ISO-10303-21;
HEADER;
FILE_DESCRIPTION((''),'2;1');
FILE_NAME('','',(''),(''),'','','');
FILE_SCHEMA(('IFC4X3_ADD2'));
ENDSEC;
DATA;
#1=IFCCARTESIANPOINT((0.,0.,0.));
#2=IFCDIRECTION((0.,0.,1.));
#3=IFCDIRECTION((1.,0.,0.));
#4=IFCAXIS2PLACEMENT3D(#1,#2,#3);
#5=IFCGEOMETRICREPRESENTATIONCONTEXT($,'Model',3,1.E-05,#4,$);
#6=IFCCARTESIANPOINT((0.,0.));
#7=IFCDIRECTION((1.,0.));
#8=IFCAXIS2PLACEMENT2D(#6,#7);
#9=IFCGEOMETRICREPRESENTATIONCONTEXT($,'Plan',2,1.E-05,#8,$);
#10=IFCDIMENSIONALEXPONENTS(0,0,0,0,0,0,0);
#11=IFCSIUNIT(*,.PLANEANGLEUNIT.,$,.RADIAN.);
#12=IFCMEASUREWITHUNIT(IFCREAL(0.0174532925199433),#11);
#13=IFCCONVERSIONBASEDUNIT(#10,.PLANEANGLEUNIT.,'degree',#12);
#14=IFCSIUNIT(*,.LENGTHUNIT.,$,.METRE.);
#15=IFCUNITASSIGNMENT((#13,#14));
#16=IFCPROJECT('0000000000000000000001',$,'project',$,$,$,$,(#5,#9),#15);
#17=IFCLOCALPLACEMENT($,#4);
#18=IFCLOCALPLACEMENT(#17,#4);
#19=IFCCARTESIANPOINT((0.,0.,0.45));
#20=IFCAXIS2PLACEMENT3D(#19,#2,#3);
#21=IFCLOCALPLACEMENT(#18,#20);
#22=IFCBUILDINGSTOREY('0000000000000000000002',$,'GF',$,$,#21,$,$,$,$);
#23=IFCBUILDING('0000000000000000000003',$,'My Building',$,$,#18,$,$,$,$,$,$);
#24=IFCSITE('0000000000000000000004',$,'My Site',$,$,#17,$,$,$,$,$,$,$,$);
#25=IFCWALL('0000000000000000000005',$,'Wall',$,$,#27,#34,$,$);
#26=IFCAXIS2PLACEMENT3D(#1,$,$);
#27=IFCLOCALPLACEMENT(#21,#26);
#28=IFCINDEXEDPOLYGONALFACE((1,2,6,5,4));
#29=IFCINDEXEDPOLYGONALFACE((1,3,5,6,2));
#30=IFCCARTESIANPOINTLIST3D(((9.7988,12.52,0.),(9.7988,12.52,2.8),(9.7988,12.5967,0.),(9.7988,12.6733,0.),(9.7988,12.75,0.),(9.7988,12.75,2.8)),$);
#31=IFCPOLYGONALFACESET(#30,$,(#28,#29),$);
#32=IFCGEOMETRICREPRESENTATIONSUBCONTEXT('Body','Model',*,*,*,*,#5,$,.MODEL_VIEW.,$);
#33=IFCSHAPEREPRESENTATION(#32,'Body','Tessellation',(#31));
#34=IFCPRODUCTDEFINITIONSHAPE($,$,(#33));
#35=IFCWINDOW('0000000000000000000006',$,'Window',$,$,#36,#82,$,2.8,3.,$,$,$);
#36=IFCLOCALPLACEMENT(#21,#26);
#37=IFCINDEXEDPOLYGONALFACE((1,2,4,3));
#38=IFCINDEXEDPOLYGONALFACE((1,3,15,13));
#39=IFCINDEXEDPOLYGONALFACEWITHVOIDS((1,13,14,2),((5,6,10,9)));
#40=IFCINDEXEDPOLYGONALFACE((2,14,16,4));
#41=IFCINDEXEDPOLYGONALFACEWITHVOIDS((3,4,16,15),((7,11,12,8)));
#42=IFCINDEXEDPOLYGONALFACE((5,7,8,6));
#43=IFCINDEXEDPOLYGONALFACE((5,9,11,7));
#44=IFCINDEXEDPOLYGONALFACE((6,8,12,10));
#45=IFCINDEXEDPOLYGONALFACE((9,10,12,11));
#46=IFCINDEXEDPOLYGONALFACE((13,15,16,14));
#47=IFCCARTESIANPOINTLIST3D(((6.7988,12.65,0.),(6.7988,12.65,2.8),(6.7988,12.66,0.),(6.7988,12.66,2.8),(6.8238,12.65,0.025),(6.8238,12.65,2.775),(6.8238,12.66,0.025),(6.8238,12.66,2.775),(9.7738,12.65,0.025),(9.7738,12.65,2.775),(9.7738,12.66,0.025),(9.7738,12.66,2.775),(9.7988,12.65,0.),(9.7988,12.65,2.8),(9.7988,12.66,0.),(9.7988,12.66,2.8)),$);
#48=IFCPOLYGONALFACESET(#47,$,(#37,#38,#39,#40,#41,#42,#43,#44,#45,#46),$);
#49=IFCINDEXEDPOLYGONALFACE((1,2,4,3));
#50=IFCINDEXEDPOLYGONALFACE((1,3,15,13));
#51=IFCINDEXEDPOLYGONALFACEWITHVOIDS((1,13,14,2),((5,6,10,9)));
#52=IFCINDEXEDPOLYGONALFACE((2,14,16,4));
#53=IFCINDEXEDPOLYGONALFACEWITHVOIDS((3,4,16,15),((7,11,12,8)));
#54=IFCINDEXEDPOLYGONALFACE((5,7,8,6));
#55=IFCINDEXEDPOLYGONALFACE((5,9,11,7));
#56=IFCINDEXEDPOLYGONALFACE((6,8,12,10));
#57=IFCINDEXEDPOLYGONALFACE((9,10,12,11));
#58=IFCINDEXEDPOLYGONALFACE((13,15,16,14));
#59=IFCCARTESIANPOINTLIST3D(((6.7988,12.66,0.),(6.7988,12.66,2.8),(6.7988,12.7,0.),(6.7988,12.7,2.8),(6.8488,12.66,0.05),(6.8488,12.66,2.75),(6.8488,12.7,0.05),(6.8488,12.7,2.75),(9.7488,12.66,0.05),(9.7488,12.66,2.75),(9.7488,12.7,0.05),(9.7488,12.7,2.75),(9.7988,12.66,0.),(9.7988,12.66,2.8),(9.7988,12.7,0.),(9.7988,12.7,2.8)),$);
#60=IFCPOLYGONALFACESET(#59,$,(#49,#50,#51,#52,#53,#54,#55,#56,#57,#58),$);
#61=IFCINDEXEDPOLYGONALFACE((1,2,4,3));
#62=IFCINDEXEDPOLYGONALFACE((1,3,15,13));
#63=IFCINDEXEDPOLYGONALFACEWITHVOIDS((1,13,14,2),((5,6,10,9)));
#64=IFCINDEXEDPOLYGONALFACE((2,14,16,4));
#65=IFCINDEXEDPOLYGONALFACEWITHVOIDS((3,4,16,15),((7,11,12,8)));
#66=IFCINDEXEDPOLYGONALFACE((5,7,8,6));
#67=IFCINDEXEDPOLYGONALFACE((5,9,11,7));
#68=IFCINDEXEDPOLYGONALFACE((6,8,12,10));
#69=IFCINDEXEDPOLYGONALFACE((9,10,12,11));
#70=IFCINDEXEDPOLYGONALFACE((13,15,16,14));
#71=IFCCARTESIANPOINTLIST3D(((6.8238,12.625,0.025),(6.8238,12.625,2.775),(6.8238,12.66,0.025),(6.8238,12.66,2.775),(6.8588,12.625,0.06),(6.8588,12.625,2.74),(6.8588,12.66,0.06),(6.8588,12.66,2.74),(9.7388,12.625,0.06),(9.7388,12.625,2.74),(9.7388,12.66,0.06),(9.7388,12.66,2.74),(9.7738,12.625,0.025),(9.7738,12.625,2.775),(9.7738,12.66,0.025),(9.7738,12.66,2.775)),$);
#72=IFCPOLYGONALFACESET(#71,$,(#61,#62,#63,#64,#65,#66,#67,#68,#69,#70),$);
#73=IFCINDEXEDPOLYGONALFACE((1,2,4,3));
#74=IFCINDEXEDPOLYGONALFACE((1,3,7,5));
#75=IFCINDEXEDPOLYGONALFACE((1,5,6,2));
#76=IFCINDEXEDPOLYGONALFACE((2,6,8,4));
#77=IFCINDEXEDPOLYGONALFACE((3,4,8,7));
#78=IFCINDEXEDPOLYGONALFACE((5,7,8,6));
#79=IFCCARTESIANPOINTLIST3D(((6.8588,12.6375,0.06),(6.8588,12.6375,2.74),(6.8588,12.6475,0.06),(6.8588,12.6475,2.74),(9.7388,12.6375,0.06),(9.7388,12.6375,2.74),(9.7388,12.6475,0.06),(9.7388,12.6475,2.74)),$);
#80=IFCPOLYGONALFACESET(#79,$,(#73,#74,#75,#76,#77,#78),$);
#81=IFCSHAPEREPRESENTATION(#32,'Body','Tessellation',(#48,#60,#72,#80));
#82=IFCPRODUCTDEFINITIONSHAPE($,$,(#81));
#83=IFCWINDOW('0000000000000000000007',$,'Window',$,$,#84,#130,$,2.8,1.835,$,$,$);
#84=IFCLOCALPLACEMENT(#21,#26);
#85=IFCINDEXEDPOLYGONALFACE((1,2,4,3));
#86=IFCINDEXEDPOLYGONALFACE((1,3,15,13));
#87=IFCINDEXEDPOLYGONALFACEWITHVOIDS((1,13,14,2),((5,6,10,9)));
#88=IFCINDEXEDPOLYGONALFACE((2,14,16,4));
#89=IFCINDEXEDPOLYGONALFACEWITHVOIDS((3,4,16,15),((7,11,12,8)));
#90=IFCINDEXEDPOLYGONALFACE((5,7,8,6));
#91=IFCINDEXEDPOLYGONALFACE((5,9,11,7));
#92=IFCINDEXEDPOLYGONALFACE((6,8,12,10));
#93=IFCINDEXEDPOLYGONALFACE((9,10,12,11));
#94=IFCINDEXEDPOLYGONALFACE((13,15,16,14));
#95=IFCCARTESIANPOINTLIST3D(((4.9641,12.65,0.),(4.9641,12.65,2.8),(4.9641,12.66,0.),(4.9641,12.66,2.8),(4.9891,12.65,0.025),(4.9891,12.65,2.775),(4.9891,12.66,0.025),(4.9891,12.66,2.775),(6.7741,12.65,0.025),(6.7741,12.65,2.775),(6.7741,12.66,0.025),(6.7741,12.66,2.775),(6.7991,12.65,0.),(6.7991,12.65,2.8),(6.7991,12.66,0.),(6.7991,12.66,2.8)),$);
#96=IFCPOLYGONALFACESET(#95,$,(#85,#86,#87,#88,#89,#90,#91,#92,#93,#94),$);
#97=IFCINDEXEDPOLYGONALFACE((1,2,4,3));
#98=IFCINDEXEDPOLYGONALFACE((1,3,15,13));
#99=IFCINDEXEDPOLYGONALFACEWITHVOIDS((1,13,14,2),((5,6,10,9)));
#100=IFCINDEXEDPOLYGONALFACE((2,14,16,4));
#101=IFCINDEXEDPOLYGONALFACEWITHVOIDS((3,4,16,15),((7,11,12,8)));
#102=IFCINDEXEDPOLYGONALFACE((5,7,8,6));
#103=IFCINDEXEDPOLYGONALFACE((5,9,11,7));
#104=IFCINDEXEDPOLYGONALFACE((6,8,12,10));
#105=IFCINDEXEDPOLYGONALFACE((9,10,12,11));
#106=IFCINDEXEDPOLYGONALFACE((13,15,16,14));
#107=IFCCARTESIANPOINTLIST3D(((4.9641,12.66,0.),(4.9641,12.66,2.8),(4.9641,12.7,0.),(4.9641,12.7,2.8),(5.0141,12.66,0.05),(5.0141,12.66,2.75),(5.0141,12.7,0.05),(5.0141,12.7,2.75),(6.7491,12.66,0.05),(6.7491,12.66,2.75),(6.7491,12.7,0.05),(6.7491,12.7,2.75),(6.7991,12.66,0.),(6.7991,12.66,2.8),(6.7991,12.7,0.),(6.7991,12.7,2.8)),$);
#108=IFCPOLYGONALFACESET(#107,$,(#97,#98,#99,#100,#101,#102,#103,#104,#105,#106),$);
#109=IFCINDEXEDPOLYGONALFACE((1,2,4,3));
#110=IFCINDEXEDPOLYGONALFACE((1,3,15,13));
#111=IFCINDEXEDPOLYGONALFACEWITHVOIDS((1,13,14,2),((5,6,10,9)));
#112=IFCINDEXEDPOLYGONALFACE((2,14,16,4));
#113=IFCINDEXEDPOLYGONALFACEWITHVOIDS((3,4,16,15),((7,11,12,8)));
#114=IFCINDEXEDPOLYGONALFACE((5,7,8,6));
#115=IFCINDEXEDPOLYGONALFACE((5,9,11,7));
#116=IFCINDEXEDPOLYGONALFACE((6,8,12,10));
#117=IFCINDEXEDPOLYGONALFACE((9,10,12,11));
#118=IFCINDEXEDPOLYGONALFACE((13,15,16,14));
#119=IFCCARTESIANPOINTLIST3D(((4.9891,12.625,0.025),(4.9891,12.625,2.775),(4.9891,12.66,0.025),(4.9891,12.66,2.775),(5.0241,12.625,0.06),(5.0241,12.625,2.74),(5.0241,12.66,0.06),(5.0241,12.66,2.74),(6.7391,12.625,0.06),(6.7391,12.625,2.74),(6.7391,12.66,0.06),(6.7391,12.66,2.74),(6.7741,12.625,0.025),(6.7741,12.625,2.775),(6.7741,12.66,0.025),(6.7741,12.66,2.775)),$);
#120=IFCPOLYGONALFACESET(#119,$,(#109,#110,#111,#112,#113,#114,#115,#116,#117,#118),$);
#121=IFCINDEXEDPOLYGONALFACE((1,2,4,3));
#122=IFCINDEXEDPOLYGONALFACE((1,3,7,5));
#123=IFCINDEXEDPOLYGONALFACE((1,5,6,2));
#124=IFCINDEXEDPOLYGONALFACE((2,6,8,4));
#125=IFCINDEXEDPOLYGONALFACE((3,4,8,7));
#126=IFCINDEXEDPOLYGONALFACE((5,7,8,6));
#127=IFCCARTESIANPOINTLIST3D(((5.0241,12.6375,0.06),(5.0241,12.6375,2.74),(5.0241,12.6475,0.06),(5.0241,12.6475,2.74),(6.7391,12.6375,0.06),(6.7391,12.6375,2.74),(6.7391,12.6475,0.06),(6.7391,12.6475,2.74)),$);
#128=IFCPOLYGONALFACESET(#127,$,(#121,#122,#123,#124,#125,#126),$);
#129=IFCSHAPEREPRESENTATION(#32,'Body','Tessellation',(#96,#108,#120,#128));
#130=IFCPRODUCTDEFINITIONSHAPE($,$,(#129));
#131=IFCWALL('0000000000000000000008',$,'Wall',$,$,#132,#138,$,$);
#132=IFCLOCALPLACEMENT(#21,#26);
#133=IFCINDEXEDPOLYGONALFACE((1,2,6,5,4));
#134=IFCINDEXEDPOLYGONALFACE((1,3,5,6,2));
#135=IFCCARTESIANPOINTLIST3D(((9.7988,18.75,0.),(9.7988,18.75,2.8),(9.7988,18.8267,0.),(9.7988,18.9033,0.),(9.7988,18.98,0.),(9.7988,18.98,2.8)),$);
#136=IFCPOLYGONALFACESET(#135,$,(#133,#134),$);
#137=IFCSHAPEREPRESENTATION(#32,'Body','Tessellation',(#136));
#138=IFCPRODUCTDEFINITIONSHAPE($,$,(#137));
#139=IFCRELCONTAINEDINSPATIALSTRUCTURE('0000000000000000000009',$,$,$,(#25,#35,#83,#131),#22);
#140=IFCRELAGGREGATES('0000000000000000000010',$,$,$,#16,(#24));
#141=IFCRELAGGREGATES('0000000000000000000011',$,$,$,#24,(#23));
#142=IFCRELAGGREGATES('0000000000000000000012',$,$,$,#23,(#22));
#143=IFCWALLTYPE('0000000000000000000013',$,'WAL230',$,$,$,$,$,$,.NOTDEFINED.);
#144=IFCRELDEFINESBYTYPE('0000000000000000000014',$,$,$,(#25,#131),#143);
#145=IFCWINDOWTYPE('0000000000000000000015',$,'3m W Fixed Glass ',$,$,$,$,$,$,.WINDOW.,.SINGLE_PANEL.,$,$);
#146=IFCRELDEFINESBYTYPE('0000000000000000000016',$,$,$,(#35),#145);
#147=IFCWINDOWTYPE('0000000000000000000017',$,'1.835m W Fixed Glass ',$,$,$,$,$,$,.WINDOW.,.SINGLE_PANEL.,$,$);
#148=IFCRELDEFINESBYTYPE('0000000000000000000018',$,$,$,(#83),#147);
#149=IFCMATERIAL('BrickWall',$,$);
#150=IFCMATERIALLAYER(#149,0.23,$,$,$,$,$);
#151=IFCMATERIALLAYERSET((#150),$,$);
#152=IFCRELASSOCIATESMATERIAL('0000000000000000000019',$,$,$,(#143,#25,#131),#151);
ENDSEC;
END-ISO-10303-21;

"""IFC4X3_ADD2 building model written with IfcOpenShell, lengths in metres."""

from ifc_helpers import new_model, entity, si_unit, converted_unit, frame, origin_with_axes, origin_2d_with_axis, place, context, subcontext, project, spatial, line, indexed_curve, outline, extrude, shape, source, transform, mapped, material, layer, layer_set, layer_usage, type_object, type_shapes, element, fill, save


model = new_model("IFC4X3_ADD2")

# Units and contexts
model_context = context("Model", 3, precision=1e-05, world=origin_with_axes())
plan_context = context("Plan", 2, precision=1e-05, world=origin_2d_with_axis())
body_context_1 = subcontext(model_context, "Body", "Model", "MODEL_VIEW")
body_context_2 = subcontext(plan_context, "Body", "Plan", "PLAN_VIEW")
ifc_project = project(units=[converted_unit("PLANEANGLEUNIT", "degree", entity("IfcReal", 0.0174532925199433), si_unit("PLANEANGLEUNIT", "RADIAN"), dimensions=[0, 0, 0, 0, 0, 0, 0]), si_unit("LENGTHUNIT", "METRE")], contexts=[model_context, plan_context])

# Site, building, storey
site_placement = place(None, origin_with_axes())
site = spatial("IfcSite", under=ifc_project, at=site_placement, Name="My Site")
building_placement = place(site_placement, origin_with_axes())
building = spatial("IfcBuilding", under=site, at=building_placement, Name="My Building")
storey_placement = place(building_placement, frame((0.0, 0.0, 0.45), z_axis=(0.0, 0.0, 1.0), x_axis=(1.0, 0.0, 0.0)))
storey = spatial("IfcBuildingStorey", under=building, at=storey_placement, Name="GF")

# Wall, openings, windows
ifc_material_1 = material(Name="BrickWall")
ifc_layer_1 = layer(ifc_material_1, 0.23)
ifc_layer_set_1 = layer_set([ifc_layer_1])
wall_type_1 = type_object("IfcWallType", Name="WAL230", PredefinedType="NOTDEFINED", material=ifc_layer_set_1)
ifc_layer_usage_1 = layer_usage(ifc_layer_set_1, "AXIS2", "POSITIVE", 0.0)
wall_1_placement = place(storey_placement, frame((9.7988, 12.75, 0.0), z_axis=(0.0, 0.0, 1.0), x_axis=(-1.0, 0.0, 0.0)))
wall_1 = element("IfcWall", 1, at=wall_1_placement, inside=storey, type_object=wall_type_1, material=ifc_layer_usage_1, Name="Wall", context=body_context_1, shape_type="SweptSolid", body=[
    extrude(outline(indexed_curve([(0.0, 0.0), (0.0, 0.23), (0.0, 0.23), (0.0, 0.0), (0.0, 0.0)], self_intersect=False)), origin_with_axes(), (0.0, 0.0, 1.0), 2.8),
])
shared_shape_1 = source(origin_with_axes(), body_context_1, "Body", "SweptSolid", [
    extrude(outline(indexed_curve([(0.0, 0.0), (3.0, 0.0), (3.0, 2.8), (0.0, 2.8)], segments=[line(1, 2, 3, 4, 1)])), frame((0.0, -0.6, 0.0), z_axis=(0.0, -1.0, 0.0), x_axis=(1.0, 0.0, 0.0)), (0.0, 0.0, -1.0), 1.2),
])
opening_1_placement = place(wall_1_placement, frame((0.0, 0.0, 0.0), z_axis=(0.0, 0.0, 1.0), x_axis=(1.0, 0.0, 0.0)))
opening_1 = element("IfcOpeningElement", 2, at=opening_1_placement, cuts=wall_1, PredefinedType="OPENING", context=body_context_1, shape_type="MappedRepresentation", body=[
    mapped(shared_shape_1, transform((0.0, 0.0, 0.0), x_axis=(1.0, 0.0, 0.0), y_axis=(0.0, 1.0, 0.0), z_axis=(0.0, 0.0, 1.0), scale=1.0)),
])
shared_shape_2 = source(origin_with_axes(), body_context_1, "Body", "SweptSolid", [
    extrude(outline(indexed_curve([(0.0, 0.0), (1.835, 0.0), (1.835, 2.8), (0.0, 2.8)], segments=[line(1, 2, 3, 4, 1)])), frame((0.0, -0.6, 0.0), z_axis=(0.0, -1.0, 0.0), x_axis=(1.0, 0.0, 0.0)), (0.0, 0.0, -1.0), 1.2),
])
opening_2_placement = place(wall_1_placement, frame((2.9997, 0.0, 0.0), z_axis=(0.0, 0.0, 1.0), x_axis=(1.0, 0.0, 0.0)))
opening_2 = element("IfcOpeningElement", 3, at=opening_2_placement, cuts=wall_1, PredefinedType="OPENING", context=body_context_1, shape_type="MappedRepresentation", body=[
    mapped(shared_shape_2, transform((0.0, 0.0, 0.0), x_axis=(1.0, 0.0, 0.0), y_axis=(0.0, 1.0, 0.0), z_axis=(0.0, 0.0, 1.0), scale=1.0)),
])
window_type_1 = type_object("IfcWindowType", Name="3m W Fixed Glass ", PartitioningType="SINGLE_PANEL", PredefinedType="WINDOW")
shared_shape_3 = source(origin_with_axes(), body_context_1, "Body", "SweptSolid", [
    extrude(outline(indexed_curve([(0.0, 0.0), (3.0, 0.0), (3.0, 2.8), (0.0, 2.8)], segments=[line(1, 2, 3, 4, 1)]), holes=[indexed_curve([(0.025, 0.025), (2.975, 0.025), (2.975, 2.775), (0.025, 2.775)], segments=[line(1, 2, 3, 4, 1)])]), frame((0.0, 0.09, 0.0), z_axis=(0.0, -1.0, 0.0), x_axis=(1.0, 0.0, 0.0)), (0.0, 0.0, -1.0), 0.01),
    extrude(outline(indexed_curve([(0.0, 0.0), (3.0, 0.0), (3.0, 2.8), (0.0, 2.8)], segments=[line(1, 2, 3, 4, 1)]), holes=[indexed_curve([(0.05, 0.05), (2.95, 0.05), (2.95, 2.75), (0.05, 2.75)], segments=[line(1, 2, 3, 4, 1)])]), frame((0.0, 0.05, 0.0), z_axis=(0.0, -1.0, 0.0), x_axis=(1.0, 0.0, 0.0)), (0.0, 0.0, -1.0), 0.04),
    extrude(outline(indexed_curve([(0.0, 0.0), (2.95, 0.0), (2.95, 2.75), (0.0, 2.75)], segments=[line(1, 2, 3, 4, 1)]), holes=[indexed_curve([(0.035, 0.035), (2.915, 0.035), (2.915, 2.715), (0.035, 2.715)], segments=[line(1, 2, 3, 4, 1)])]), frame((0.025, 0.09, 0.025), z_axis=(0.0, -1.0, 0.0), x_axis=(1.0, 0.0, 0.0)), (0.0, 0.0, -1.0), 0.035),
    extrude(outline(indexed_curve([(0.035, 0.035), (2.915, 0.035), (2.915, 2.715), (0.035, 2.715)], segments=[line(1, 2, 3, 4, 1)])), frame((0.025, 0.1025, 0.025), z_axis=(0.0, -1.0, 0.0), x_axis=(1.0, 0.0, 0.0)), (0.0, 0.0, -1.0), 0.01),
])
shared_shape_4 = source(origin_with_axes(), body_context_2, "Body", "Curve2D", [
    entity("IfcIndexedPolyCurve", entity("IfcCartesianPointList2D", [[0.05, 0.05], [2.95, 0.05]])),
    entity("IfcIndexedPolyCurve", entity("IfcCartesianPointList2D", [[0.0, 0.1], [0.025, 0.1], [0.025, 0.09], [0.05, 0.09], [0.05, 0.05], [0.0, 0.05]]), [entity("IfcLineIndex", [1, 2, 3, 4, 5, 6, 1])]),
    entity("IfcIndexedPolyCurve", entity("IfcCartesianPointList2D", [[3.0, 0.1], [2.975, 0.1], [2.975, 0.09], [2.95, 0.09], [2.95, 0.05], [3.0, 0.05]]), [entity("IfcLineIndex", [1, 2, 3, 4, 5, 6, 1])]),
    entity("IfcIndexedPolyCurve", entity("IfcCartesianPointList2D", [[0.025, 0.09], [0.06, 0.09], [0.06, 0.125], [0.025, 0.125]]), [entity("IfcLineIndex", [1, 2, 3, 4, 1])]),
    entity("IfcIndexedPolyCurve", entity("IfcCartesianPointList2D", [[2.975, 0.09], [2.94, 0.09], [2.94, 0.125], [2.975, 0.125]]), [entity("IfcLineIndex", [1, 2, 3, 4, 1])]),
    entity("IfcIndexedPolyCurve", entity("IfcCartesianPointList2D", [[0.06, 0.09], [2.94, 0.09]])),
    entity("IfcIndexedPolyCurve", entity("IfcCartesianPointList2D", [[0.06, 0.125], [2.94, 0.125]])),
    entity("IfcIndexedPolyCurve", entity("IfcCartesianPointList2D", [[0.06, 0.1075], [2.94, 0.1075]])),
])
type_shapes(window_type_1, [shared_shape_3, shared_shape_4])
window_1_placement = place(opening_1_placement, frame((0.0, 0.0, 0.0), z_axis=(0.0, 0.0, 1.0), x_axis=(1.0, 0.0, 0.0)))
window_1 = element("IfcWindow", 4, at=window_1_placement, inside=storey, type_object=window_type_1, Name="Window", OverallHeight=2.8, OverallWidth=3.0, shapes=[
    shape(body_context_1, "Body", "MappedRepresentation", [mapped(shared_shape_3, transform((0.0, 0.0, 0.0), x_axis=(1.0, 0.0, 0.0), y_axis=(0.0, 1.0, 0.0), z_axis=(0.0, 0.0, 1.0), scale=1.0))]),
    shape(body_context_2, "Body", "MappedRepresentation", [mapped(shared_shape_4, transform((0.0, 0.0, 0.0), x_axis=(1.0, 0.0, 0.0), y_axis=(0.0, 1.0, 0.0), z_axis=(0.0, 0.0, 1.0), scale=1.0))]),
])
fill(opening_1, window_1)
window_type_2 = type_object("IfcWindowType", Name="1.835m W Fixed Glass ", PartitioningType="SINGLE_PANEL", PredefinedType="WINDOW")
shared_shape_5 = source(origin_with_axes(), body_context_1, "Body", "SweptSolid", [
    extrude(outline(indexed_curve([(0.0, 0.0), (1.835, 0.0), (1.835, 2.8), (0.0, 2.8)], segments=[line(1, 2, 3, 4, 1)]), holes=[indexed_curve([(0.025, 0.025), (1.81, 0.025), (1.81, 2.775), (0.025, 2.775)], segments=[line(1, 2, 3, 4, 1)])]), frame((0.0, 0.09, 0.0), z_axis=(0.0, -1.0, 0.0), x_axis=(1.0, 0.0, 0.0)), (0.0, 0.0, -1.0), 0.01),
    extrude(outline(indexed_curve([(0.0, 0.0), (1.835, 0.0), (1.835, 2.8), (0.0, 2.8)], segments=[line(1, 2, 3, 4, 1)]), holes=[indexed_curve([(0.05, 0.05), (1.785, 0.05), (1.785, 2.75), (0.05, 2.75)], segments=[line(1, 2, 3, 4, 1)])]), frame((0.0, 0.05, 0.0), z_axis=(0.0, -1.0, 0.0), x_axis=(1.0, 0.0, 0.0)), (0.0, 0.0, -1.0), 0.04),
    extrude(outline(indexed_curve([(0.0, 0.0), (1.785, 0.0), (1.785, 2.75), (0.0, 2.75)], segments=[line(1, 2, 3, 4, 1)]), holes=[indexed_curve([(0.035, 0.035), (1.75, 0.035), (1.75, 2.715), (0.035, 2.715)], segments=[line(1, 2, 3, 4, 1)])]), frame((0.025, 0.09, 0.025), z_axis=(0.0, -1.0, 0.0), x_axis=(1.0, 0.0, 0.0)), (0.0, 0.0, -1.0), 0.035),
    extrude(outline(indexed_curve([(0.035, 0.035), (1.75, 0.035), (1.75, 2.715), (0.035, 2.715)], segments=[line(1, 2, 3, 4, 1)])), frame((0.025, 0.1025, 0.025), z_axis=(0.0, -1.0, 0.0), x_axis=(1.0, 0.0, 0.0)), (0.0, 0.0, -1.0), 0.01),
])
shared_shape_6 = source(origin_with_axes(), body_context_2, "Body", "Curve2D", [
    entity("IfcIndexedPolyCurve", entity("IfcCartesianPointList2D", [[0.05, 0.05], [1.785, 0.05]])),
    entity("IfcIndexedPolyCurve", entity("IfcCartesianPointList2D", [[0.0, 0.1], [0.025, 0.1], [0.025, 0.09], [0.05, 0.09], [0.05, 0.05], [0.0, 0.05]]), [entity("IfcLineIndex", [1, 2, 3, 4, 5, 6, 1])]),
    entity("IfcIndexedPolyCurve", entity("IfcCartesianPointList2D", [[1.835, 0.1], [1.81, 0.1], [1.81, 0.09], [1.785, 0.09], [1.785, 0.05], [1.835, 0.05]]), [entity("IfcLineIndex", [1, 2, 3, 4, 5, 6, 1])]),
    entity("IfcIndexedPolyCurve", entity("IfcCartesianPointList2D", [[0.025, 0.09], [0.06, 0.09], [0.06, 0.125], [0.025, 0.125]]), [entity("IfcLineIndex", [1, 2, 3, 4, 1])]),
    entity("IfcIndexedPolyCurve", entity("IfcCartesianPointList2D", [[1.81, 0.09], [1.775, 0.09], [1.775, 0.125], [1.81, 0.125]]), [entity("IfcLineIndex", [1, 2, 3, 4, 1])]),
    entity("IfcIndexedPolyCurve", entity("IfcCartesianPointList2D", [[0.06, 0.09], [1.775, 0.09]])),
    entity("IfcIndexedPolyCurve", entity("IfcCartesianPointList2D", [[0.06, 0.125], [1.775, 0.125]])),
    entity("IfcIndexedPolyCurve", entity("IfcCartesianPointList2D", [[0.06, 0.1075], [1.775, 0.1075]])),
])
type_shapes(window_type_2, [shared_shape_5, shared_shape_6])
window_2_placement = place(opening_2_placement, frame((0.0, 0.0, 0.0), z_axis=(0.0, 0.0, 1.0), x_axis=(1.0, 0.0, 0.0)))
window_2 = element("IfcWindow", 5, at=window_2_placement, inside=storey, type_object=window_type_2, Name="Window", OverallHeight=2.8, OverallWidth=1.835, shapes=[
    shape(body_context_1, "Body", "MappedRepresentation", [mapped(shared_shape_5, transform((0.0, 0.0, 0.0), x_axis=(1.0, 0.0, 0.0), y_axis=(0.0, 1.0, 0.0), z_axis=(0.0, 0.0, 1.0), scale=1.0))]),
    shape(body_context_2, "Body", "MappedRepresentation", [mapped(shared_shape_6, transform((0.0, 0.0, 0.0), x_axis=(1.0, 0.0, 0.0), y_axis=(0.0, 1.0, 0.0), z_axis=(0.0, 0.0, 1.0), scale=1.0))]),
])
fill(opening_2, window_2)

# Wall
ifc_layer_usage_2 = layer_usage(ifc_layer_set_1, "AXIS2", "POSITIVE", 0.0)
wall_2_placement = place(storey_placement, frame((9.7988, 18.98, 0.0), z_axis=(0.0, 0.0, 1.0), x_axis=(-1.0, 0.0, 0.0)))
element("IfcWall", 6, at=wall_2_placement, inside=storey, type_object=wall_type_1, material=ifc_layer_usage_2, Name="Wall", context=body_context_1, shape_type="SweptSolid", body=[
    extrude(outline(indexed_curve([(0.0, 0.0), (0.0, 0.23), (0.0, 0.23), (0.0, 0.0), (0.0, 0.0)], self_intersect=False)), origin_with_axes(), (0.0, 0.0, 1.0), 2.8),
])

save(model, "model.ifc")
